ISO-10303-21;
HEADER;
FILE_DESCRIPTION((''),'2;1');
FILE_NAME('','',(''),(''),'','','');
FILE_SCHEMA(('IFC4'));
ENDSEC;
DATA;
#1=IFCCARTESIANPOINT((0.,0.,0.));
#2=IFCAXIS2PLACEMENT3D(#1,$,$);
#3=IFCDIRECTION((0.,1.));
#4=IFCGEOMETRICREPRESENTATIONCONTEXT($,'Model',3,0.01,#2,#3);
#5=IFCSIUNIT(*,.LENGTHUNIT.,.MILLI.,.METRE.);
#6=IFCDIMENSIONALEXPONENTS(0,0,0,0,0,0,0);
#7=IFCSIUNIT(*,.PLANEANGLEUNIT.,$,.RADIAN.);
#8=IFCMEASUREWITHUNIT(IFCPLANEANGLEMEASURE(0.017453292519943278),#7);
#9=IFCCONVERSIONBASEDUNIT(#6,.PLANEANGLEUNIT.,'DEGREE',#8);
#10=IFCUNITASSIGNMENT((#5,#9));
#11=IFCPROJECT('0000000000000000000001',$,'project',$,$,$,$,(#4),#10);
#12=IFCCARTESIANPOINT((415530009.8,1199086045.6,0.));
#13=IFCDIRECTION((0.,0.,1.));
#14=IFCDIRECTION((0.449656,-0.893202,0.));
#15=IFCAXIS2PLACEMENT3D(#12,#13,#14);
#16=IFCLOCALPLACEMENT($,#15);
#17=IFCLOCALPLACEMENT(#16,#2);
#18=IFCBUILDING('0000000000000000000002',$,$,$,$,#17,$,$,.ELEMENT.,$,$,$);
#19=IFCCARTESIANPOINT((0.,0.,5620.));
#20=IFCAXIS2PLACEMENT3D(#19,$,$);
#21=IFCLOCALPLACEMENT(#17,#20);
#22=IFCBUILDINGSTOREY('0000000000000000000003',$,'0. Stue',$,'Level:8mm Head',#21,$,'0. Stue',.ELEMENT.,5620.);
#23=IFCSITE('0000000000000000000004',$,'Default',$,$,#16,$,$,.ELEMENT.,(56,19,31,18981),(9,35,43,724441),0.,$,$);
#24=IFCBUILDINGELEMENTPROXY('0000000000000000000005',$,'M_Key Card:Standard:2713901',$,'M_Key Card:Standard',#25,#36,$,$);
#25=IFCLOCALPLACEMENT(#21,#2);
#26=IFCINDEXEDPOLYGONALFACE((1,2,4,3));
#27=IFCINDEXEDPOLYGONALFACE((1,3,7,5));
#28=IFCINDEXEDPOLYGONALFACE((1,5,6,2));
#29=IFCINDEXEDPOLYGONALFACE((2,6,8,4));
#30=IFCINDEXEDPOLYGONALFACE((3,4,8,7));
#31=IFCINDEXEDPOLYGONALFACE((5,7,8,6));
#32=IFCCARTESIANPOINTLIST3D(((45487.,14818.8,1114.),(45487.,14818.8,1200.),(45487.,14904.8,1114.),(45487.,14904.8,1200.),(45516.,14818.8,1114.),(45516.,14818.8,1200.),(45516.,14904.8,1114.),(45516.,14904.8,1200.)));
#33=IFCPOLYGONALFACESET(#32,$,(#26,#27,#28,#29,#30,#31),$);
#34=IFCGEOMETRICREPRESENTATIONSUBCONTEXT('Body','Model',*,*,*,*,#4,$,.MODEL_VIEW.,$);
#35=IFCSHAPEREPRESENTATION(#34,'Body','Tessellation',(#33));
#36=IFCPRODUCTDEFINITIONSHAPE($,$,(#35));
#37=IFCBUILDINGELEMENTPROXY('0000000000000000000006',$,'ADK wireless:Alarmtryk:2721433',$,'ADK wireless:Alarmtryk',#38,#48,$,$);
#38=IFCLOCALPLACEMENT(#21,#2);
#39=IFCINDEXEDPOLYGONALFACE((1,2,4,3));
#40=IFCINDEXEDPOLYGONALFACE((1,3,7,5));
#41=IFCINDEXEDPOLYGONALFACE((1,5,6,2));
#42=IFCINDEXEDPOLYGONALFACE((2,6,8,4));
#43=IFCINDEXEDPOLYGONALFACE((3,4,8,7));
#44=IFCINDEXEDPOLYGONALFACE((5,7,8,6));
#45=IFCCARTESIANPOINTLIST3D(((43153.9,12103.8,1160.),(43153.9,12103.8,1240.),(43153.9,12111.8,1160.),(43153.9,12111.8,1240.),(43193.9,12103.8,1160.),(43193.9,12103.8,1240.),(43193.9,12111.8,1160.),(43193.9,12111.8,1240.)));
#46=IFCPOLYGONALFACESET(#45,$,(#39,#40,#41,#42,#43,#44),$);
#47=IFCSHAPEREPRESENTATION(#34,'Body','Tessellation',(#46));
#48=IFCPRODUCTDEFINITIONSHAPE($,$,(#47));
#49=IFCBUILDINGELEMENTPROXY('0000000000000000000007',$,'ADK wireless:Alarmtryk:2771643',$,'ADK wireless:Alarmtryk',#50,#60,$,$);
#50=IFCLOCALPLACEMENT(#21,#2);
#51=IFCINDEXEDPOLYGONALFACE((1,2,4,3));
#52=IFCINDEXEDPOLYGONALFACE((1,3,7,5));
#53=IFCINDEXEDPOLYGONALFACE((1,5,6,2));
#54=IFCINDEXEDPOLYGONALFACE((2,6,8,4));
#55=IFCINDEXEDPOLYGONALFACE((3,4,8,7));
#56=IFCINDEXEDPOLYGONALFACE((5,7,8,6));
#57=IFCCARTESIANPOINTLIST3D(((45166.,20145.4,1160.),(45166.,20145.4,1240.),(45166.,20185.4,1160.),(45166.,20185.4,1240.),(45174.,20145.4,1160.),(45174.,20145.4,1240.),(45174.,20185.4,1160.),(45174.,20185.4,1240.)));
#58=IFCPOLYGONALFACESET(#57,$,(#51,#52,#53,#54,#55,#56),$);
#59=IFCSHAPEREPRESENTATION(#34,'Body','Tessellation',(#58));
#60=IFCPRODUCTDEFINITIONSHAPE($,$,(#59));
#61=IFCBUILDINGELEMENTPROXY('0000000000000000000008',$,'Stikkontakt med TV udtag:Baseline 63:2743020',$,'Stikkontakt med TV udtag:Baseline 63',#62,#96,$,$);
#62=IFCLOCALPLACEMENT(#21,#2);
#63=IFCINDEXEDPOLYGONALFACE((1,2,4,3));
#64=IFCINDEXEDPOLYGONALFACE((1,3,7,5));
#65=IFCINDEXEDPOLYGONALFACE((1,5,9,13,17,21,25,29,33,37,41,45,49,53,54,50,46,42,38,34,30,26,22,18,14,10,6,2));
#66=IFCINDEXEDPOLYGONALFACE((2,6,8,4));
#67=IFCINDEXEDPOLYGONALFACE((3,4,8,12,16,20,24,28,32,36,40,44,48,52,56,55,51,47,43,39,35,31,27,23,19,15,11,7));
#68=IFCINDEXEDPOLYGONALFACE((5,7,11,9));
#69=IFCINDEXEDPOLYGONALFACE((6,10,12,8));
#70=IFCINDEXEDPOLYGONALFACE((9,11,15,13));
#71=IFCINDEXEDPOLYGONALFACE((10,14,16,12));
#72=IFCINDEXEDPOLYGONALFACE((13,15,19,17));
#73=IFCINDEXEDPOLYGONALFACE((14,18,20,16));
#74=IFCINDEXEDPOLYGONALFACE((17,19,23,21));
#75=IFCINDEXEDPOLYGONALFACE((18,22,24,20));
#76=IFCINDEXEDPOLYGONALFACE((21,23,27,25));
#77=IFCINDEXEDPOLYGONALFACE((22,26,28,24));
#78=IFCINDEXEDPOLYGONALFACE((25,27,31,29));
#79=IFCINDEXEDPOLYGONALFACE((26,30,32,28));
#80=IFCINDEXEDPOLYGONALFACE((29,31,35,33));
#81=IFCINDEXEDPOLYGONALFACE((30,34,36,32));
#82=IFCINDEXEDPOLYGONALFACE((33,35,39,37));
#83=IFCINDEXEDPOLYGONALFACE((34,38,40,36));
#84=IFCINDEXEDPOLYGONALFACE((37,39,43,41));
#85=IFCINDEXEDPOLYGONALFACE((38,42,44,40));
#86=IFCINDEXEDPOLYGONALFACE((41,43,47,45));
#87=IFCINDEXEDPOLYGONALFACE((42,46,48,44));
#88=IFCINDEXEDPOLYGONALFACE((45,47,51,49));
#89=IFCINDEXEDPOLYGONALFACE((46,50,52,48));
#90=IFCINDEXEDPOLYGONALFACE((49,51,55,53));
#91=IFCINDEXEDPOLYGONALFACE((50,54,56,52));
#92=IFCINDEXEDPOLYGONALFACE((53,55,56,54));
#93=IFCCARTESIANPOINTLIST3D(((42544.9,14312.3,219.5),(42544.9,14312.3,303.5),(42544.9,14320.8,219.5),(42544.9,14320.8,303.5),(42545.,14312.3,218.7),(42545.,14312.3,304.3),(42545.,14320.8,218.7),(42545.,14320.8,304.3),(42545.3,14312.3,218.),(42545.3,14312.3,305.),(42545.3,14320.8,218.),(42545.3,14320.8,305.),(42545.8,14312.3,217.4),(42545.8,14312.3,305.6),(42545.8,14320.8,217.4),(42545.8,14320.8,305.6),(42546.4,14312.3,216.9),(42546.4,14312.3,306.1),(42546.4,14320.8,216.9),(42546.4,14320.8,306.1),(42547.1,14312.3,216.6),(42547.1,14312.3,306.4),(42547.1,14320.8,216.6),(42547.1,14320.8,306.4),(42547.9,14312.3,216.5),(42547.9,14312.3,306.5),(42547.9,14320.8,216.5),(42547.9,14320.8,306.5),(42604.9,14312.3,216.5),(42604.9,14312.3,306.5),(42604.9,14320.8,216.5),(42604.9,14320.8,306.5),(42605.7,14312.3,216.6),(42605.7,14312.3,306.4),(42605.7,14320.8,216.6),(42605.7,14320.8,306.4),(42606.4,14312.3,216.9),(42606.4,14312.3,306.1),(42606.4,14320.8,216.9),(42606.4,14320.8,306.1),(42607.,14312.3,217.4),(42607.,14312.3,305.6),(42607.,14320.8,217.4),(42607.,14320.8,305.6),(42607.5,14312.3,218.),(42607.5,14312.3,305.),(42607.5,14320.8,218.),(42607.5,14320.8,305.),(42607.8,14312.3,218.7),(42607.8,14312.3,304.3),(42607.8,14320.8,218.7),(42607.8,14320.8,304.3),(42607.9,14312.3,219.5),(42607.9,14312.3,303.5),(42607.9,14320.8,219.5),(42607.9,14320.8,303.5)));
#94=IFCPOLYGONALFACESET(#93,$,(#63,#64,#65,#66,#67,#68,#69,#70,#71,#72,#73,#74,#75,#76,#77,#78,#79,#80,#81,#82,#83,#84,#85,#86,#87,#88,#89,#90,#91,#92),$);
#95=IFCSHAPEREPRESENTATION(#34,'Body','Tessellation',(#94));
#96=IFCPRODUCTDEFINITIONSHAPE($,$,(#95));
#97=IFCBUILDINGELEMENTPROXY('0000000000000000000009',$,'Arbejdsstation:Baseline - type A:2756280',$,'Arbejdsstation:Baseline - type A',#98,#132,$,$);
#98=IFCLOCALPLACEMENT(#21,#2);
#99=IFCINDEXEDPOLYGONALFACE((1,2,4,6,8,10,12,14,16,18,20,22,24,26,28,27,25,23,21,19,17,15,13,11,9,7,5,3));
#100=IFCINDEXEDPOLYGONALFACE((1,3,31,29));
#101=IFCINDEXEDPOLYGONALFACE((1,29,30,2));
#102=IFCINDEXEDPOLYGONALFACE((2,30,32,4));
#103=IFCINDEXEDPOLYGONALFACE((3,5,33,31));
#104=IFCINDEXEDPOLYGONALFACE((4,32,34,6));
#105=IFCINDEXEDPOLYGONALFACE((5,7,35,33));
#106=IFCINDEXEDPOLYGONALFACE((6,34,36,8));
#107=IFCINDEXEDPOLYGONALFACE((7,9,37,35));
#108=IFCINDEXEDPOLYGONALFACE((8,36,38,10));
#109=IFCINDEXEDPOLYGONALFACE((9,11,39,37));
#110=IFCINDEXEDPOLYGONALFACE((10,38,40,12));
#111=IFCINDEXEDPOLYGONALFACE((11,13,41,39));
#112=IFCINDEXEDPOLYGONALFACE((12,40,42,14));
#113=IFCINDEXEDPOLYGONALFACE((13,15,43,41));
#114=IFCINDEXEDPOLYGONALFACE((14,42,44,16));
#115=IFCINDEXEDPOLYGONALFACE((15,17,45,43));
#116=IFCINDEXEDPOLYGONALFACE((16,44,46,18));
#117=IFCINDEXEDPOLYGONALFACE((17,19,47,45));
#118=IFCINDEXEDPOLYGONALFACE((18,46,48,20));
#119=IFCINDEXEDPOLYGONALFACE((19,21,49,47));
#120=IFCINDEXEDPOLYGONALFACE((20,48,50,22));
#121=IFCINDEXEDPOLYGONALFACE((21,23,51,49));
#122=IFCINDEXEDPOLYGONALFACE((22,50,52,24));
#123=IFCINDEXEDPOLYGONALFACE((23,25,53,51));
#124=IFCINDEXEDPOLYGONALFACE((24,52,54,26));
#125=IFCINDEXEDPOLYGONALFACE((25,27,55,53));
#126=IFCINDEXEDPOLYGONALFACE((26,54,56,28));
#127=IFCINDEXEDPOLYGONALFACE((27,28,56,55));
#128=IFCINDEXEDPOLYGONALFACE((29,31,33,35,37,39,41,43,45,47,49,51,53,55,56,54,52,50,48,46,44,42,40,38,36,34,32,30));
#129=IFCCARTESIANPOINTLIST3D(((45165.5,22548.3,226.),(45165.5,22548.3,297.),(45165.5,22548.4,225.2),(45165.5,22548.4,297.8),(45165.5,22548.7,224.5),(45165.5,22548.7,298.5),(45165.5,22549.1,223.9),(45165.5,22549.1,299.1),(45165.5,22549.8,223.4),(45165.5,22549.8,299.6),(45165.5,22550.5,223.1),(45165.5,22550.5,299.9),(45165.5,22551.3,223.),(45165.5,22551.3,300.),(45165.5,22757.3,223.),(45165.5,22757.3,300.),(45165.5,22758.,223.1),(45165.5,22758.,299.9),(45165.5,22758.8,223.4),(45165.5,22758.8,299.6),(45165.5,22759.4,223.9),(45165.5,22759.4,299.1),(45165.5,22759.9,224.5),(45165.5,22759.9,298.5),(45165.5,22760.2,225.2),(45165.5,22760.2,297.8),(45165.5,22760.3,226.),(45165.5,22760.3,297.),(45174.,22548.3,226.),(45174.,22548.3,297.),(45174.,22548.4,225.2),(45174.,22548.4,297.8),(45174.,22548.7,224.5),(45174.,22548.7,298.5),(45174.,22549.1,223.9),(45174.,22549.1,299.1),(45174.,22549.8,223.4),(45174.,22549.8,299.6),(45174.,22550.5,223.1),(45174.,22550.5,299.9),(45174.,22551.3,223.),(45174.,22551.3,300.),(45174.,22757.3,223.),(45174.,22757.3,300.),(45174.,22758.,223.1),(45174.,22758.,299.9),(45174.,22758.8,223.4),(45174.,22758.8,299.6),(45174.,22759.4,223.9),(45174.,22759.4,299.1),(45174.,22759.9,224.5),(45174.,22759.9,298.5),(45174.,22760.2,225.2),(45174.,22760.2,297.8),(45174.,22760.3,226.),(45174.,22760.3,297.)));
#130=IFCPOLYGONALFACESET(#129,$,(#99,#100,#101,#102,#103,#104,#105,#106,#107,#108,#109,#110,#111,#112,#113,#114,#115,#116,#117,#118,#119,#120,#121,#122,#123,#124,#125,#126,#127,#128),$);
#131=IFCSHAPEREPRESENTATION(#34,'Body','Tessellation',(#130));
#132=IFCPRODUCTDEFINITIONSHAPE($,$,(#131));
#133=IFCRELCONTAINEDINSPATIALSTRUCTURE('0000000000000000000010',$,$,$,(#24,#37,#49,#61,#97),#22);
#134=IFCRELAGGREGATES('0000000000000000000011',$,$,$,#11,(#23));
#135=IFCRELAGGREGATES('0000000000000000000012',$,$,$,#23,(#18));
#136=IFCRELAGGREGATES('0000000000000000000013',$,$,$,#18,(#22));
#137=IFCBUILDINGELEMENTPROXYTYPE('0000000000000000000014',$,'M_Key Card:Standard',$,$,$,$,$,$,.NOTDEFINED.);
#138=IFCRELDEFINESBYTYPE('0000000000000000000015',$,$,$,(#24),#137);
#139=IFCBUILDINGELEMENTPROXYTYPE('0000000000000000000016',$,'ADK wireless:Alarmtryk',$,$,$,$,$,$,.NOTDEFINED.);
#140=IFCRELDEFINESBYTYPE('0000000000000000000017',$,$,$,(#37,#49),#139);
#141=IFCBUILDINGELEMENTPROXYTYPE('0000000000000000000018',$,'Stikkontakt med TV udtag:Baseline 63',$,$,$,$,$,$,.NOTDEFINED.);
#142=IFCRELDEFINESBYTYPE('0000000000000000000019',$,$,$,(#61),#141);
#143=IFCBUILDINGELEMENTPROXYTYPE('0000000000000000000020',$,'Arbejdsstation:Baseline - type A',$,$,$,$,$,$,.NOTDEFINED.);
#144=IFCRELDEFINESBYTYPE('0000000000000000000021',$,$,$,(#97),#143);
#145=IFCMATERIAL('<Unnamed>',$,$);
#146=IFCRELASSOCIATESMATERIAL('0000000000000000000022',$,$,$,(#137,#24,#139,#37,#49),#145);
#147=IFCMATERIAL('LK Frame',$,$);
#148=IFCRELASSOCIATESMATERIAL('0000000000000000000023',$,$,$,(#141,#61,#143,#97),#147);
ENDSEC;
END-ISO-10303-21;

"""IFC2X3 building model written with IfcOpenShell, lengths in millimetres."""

from ifc_helpers import new_model, entity, si_unit, converted_unit, direction, frame, frame_2d, origin, origin_2d_with_axis, place, context, subcontext, project, spatial, polyline, circle_curve, parameter, trimmed, segment, composite_curve, rectangle, outline, extrude, source, transform, mapped, material, type_object, type_shapes, element, save


model = new_model("IFC2X3")

# Units and contexts
model_context = context("Model", 3, precision=0.01, world=origin(), true_north=direction((0.0, 1.0)))
body_context = subcontext(model_context, "Body", "Model", "MODEL_VIEW")
ifc_project = project(units=[si_unit("LENGTHUNIT", "METRE", prefix="MILLI"), converted_unit("PLANEANGLEUNIT", "DEGREE", entity("IfcPlaneAngleMeasure", 0.017453292519943278), si_unit("PLANEANGLEUNIT", "RADIAN"), dimensions=[0, 0, 0, 0, 0, 0, 0])], contexts=[model_context])

# Site, building, storey
site_placement = place(None, frame((415530009.8, 1199086045.6, 0.0), z_axis=(0.0, 0.0, 1.0), x_axis=(0.449656, -0.893202, 0.0)))
site = spatial("IfcSite", under=ifc_project, at=site_placement, Name="Default", CompositionType="ELEMENT", RefLatitude=(56, 19, 31, 18981), RefLongitude=(9, 35, 43, 724441), RefElevation=0.0)
building_placement = place(site_placement, origin())
building = spatial("IfcBuilding", under=site, at=building_placement, CompositionType="ELEMENT")
storey_placement = place(building_placement, frame((0.0, 0.0, 5620.0)))
storey = spatial("IfcBuildingStorey", under=building, at=storey_placement, Name="0. Stue", ObjectType="Level:8mm Head", LongName="0. Stue", CompositionType="ELEMENT", Elevation=5620.0)

# Building element proxies
ifc_material_1 = material(Name="LK Frame")
ifc_material_2 = material(Name="<Unnamed>")
building_element_proxy_type_1 = type_object("IfcBuildingElementProxyType", Name="M_Key Card:Standard", PredefinedType="NOTDEFINED", material=ifc_material_2)
shared_shape_1 = source(origin(), body_context, "Body", "SweptSolid", [
    extrude(rectangle(XDim=86.0, YDim=86.0, at=origin_2d_with_axis()), frame((0.0, -43.0, 0.0), z_axis=(0.0, 0.0, 1.0), x_axis=(-1.0, 0.0, 0.0)), (0.0, 0.0, 1.0), 29.0),
])
type_shapes(building_element_proxy_type_1, [shared_shape_1])
proxy_1_placement = place(storey_placement, frame((45487.0, 14861.8, 1200.0), z_axis=(1.0, 0.0, 0.0), x_axis=(0.0, 1.0, 0.0)))
element("IfcBuildingElementProxy", 1, at=proxy_1_placement, inside=storey, type_object=building_element_proxy_type_1, material=ifc_material_2, Name="M_Key Card:Standard:2713901", ObjectType="M_Key Card:Standard", context=body_context, shape_type="MappedRepresentation", body=[
    mapped(shared_shape_1, transform((0.0, 0.0, 0.0), scale=1.0)),
])
building_element_proxy_type_2 = type_object("IfcBuildingElementProxyType", Name="ADK wireless:Alarmtryk", PredefinedType="NOTDEFINED", material=ifc_material_2)
shared_shape_2 = source(origin(), body_context, "Body", "SweptSolid", [
    extrude(rectangle(XDim=8.0, YDim=40.0, at=origin_2d_with_axis()), frame((0.0, 4.0, -40.0), z_axis=(0.0, 0.0, 1.0), x_axis=(0.0, -1.0, 0.0)), (0.0, 0.0, 1.0), 80.0),
])
type_shapes(building_element_proxy_type_2, [shared_shape_2])
proxy_2_placement = place(storey_placement, frame((43173.9, 12103.8, 1200.0)))
element("IfcBuildingElementProxy", 2, at=proxy_2_placement, inside=storey, type_object=building_element_proxy_type_2, material=ifc_material_2, Name="ADK wireless:Alarmtryk:2721433", ObjectType="ADK wireless:Alarmtryk", context=body_context, shape_type="MappedRepresentation", body=[
    mapped(shared_shape_2, transform((0.0, 0.0, 0.0), scale=1.0)),
])
proxy_3_placement = place(storey_placement, frame((45174.0, 20165.4, 1200.0), z_axis=(0.0, 0.0, 1.0), x_axis=(0.0, 1.0, 0.0)))
element("IfcBuildingElementProxy", 3, at=proxy_3_placement, inside=storey, type_object=building_element_proxy_type_2, material=ifc_material_2, Name="ADK wireless:Alarmtryk:2771643", ObjectType="ADK wireless:Alarmtryk", context=body_context, shape_type="MappedRepresentation", body=[
    mapped(shared_shape_2, transform((0.0, 0.0, 0.0), scale=1.0)),
])
building_element_proxy_type_3 = type_object("IfcBuildingElementProxyType", Name="Stikkontakt med TV udtag:Baseline 63", PredefinedType="NOTDEFINED", material=ifc_material_1)
shared_shape_3 = source(origin(), body_context, "Body", "SweptSolid", [
    extrude(outline(composite_curve([segment(polyline([(-42.0, -31.5), (42.0, -31.5)]), True, "CONTINUOUS"), segment(trimmed(circle_curve(frame_2d((42.0, -28.5), x_axis=(-1.0, 0.0)), 3.0), [parameter(90.0)], [parameter(180.0)], True, "PARAMETER"), True, "CONTINUOUS"), segment(polyline([(45.0, -28.5), (45.0, 28.5)]), True, "CONTINUOUS"), segment(trimmed(circle_curve(frame_2d((42.0, 28.5), x_axis=(-1.0, 0.0)), 3.0), [parameter(180.0)], [parameter(270.0)], True, "PARAMETER"), True, "CONTINUOUS"), segment(polyline([(42.0, 31.5), (-42.0, 31.5)]), True, "CONTINUOUS"), segment(trimmed(circle_curve(frame_2d((-42.0, 28.5), x_axis=(1.0, 0.0)), 3.0), [parameter(90.0)], [parameter(180.0)], True, "PARAMETER"), True, "CONTINUOUS"), segment(polyline([(-45.0, 28.5), (-45.0, -28.5)]), True, "CONTINUOUS"), segment(trimmed(circle_curve(frame_2d((-42.0, -28.5), x_axis=(1.0, 0.0)), 3.0), [parameter(180.0)], [parameter(270.0)], True, "PARAMETER"), True, "CONTINUOUS")], self_intersect=False)), frame((0.0, -38.5, 0.0), z_axis=(0.0, 0.0, 1.0), x_axis=(0.0, 1.0, 0.0)), (0.0, 0.0, 1.0), 8.5),
])
type_shapes(building_element_proxy_type_3, [shared_shape_3])
proxy_4_placement = place(storey_placement, frame((42576.4, 14320.8, 300.0), z_axis=(0.0, -1.0, 0.0), x_axis=(1.0, 0.0, 0.0)))
element("IfcBuildingElementProxy", 4, at=proxy_4_placement, inside=storey, type_object=building_element_proxy_type_3, material=ifc_material_1, Name="Stikkontakt med TV udtag:Baseline 63:2743020", ObjectType="Stikkontakt med TV udtag:Baseline 63", context=body_context, shape_type="MappedRepresentation", body=[
    mapped(shared_shape_3, transform((0.0, 0.0, 0.0), scale=1.0)),
])
building_element_proxy_type_4 = type_object("IfcBuildingElementProxyType", Name="Arbejdsstation:Baseline - type A", PredefinedType="NOTDEFINED", material=ifc_material_1)
shared_shape_4 = source(origin(), body_context, "Body", "SweptSolid", [
    extrude(outline(composite_curve([segment(polyline([(-35.5, -106.0), (35.5, -106.0)]), True, "CONTINUOUS"), segment(trimmed(circle_curve(frame_2d((35.5, -103.0), x_axis=(-1.0, 0.0)), 3.0), [parameter(90.0)], [parameter(180.0)], True, "PARAMETER"), True, "CONTINUOUS"), segment(polyline([(38.5, -103.0), (38.5, 103.0)]), True, "CONTINUOUS"), segment(trimmed(circle_curve(frame_2d((35.5, 103.0), x_axis=(-1.0, 0.0)), 3.0), [parameter(180.0)], [parameter(270.0)], True, "PARAMETER"), True, "CONTINUOUS"), segment(polyline([(35.5, 106.0), (-35.5, 106.0)]), True, "CONTINUOUS"), segment(trimmed(circle_curve(frame_2d((-35.5, 103.0), x_axis=(1.0, 0.0)), 3.0), [parameter(90.0)], [parameter(180.0)], True, "PARAMETER"), True, "CONTINUOUS"), segment(polyline([(-38.5, 103.0), (-38.5, -103.0)]), True, "CONTINUOUS"), segment(trimmed(circle_curve(frame_2d((-35.5, -103.0), x_axis=(1.0, 0.0)), 3.0), [parameter(180.0)], [parameter(270.0)], True, "PARAMETER"), True, "CONTINUOUS")], self_intersect=False)), frame((-3.5, -38.5, 0.0), z_axis=(0.0, 0.0, 1.0), x_axis=(0.0, 1.0, 0.0)), (0.0, 0.0, 1.0), 8.5),
])
type_shapes(building_element_proxy_type_4, [shared_shape_4])
proxy_5_placement = place(storey_placement, frame((45174.0, 22650.8, 300.0), z_axis=(-1.0, 0.0, 0.0), x_axis=(0.0, -1.0, 0.0)))
element("IfcBuildingElementProxy", 5, at=proxy_5_placement, inside=storey, type_object=building_element_proxy_type_4, material=ifc_material_1, Name="Arbejdsstation:Baseline - type A:2756280", ObjectType="Arbejdsstation:Baseline - type A", context=body_context, shape_type="MappedRepresentation", body=[
    mapped(shared_shape_4, transform((0.0, 0.0, 0.0), scale=1.0)),
])

save(model, "model.ifc")
